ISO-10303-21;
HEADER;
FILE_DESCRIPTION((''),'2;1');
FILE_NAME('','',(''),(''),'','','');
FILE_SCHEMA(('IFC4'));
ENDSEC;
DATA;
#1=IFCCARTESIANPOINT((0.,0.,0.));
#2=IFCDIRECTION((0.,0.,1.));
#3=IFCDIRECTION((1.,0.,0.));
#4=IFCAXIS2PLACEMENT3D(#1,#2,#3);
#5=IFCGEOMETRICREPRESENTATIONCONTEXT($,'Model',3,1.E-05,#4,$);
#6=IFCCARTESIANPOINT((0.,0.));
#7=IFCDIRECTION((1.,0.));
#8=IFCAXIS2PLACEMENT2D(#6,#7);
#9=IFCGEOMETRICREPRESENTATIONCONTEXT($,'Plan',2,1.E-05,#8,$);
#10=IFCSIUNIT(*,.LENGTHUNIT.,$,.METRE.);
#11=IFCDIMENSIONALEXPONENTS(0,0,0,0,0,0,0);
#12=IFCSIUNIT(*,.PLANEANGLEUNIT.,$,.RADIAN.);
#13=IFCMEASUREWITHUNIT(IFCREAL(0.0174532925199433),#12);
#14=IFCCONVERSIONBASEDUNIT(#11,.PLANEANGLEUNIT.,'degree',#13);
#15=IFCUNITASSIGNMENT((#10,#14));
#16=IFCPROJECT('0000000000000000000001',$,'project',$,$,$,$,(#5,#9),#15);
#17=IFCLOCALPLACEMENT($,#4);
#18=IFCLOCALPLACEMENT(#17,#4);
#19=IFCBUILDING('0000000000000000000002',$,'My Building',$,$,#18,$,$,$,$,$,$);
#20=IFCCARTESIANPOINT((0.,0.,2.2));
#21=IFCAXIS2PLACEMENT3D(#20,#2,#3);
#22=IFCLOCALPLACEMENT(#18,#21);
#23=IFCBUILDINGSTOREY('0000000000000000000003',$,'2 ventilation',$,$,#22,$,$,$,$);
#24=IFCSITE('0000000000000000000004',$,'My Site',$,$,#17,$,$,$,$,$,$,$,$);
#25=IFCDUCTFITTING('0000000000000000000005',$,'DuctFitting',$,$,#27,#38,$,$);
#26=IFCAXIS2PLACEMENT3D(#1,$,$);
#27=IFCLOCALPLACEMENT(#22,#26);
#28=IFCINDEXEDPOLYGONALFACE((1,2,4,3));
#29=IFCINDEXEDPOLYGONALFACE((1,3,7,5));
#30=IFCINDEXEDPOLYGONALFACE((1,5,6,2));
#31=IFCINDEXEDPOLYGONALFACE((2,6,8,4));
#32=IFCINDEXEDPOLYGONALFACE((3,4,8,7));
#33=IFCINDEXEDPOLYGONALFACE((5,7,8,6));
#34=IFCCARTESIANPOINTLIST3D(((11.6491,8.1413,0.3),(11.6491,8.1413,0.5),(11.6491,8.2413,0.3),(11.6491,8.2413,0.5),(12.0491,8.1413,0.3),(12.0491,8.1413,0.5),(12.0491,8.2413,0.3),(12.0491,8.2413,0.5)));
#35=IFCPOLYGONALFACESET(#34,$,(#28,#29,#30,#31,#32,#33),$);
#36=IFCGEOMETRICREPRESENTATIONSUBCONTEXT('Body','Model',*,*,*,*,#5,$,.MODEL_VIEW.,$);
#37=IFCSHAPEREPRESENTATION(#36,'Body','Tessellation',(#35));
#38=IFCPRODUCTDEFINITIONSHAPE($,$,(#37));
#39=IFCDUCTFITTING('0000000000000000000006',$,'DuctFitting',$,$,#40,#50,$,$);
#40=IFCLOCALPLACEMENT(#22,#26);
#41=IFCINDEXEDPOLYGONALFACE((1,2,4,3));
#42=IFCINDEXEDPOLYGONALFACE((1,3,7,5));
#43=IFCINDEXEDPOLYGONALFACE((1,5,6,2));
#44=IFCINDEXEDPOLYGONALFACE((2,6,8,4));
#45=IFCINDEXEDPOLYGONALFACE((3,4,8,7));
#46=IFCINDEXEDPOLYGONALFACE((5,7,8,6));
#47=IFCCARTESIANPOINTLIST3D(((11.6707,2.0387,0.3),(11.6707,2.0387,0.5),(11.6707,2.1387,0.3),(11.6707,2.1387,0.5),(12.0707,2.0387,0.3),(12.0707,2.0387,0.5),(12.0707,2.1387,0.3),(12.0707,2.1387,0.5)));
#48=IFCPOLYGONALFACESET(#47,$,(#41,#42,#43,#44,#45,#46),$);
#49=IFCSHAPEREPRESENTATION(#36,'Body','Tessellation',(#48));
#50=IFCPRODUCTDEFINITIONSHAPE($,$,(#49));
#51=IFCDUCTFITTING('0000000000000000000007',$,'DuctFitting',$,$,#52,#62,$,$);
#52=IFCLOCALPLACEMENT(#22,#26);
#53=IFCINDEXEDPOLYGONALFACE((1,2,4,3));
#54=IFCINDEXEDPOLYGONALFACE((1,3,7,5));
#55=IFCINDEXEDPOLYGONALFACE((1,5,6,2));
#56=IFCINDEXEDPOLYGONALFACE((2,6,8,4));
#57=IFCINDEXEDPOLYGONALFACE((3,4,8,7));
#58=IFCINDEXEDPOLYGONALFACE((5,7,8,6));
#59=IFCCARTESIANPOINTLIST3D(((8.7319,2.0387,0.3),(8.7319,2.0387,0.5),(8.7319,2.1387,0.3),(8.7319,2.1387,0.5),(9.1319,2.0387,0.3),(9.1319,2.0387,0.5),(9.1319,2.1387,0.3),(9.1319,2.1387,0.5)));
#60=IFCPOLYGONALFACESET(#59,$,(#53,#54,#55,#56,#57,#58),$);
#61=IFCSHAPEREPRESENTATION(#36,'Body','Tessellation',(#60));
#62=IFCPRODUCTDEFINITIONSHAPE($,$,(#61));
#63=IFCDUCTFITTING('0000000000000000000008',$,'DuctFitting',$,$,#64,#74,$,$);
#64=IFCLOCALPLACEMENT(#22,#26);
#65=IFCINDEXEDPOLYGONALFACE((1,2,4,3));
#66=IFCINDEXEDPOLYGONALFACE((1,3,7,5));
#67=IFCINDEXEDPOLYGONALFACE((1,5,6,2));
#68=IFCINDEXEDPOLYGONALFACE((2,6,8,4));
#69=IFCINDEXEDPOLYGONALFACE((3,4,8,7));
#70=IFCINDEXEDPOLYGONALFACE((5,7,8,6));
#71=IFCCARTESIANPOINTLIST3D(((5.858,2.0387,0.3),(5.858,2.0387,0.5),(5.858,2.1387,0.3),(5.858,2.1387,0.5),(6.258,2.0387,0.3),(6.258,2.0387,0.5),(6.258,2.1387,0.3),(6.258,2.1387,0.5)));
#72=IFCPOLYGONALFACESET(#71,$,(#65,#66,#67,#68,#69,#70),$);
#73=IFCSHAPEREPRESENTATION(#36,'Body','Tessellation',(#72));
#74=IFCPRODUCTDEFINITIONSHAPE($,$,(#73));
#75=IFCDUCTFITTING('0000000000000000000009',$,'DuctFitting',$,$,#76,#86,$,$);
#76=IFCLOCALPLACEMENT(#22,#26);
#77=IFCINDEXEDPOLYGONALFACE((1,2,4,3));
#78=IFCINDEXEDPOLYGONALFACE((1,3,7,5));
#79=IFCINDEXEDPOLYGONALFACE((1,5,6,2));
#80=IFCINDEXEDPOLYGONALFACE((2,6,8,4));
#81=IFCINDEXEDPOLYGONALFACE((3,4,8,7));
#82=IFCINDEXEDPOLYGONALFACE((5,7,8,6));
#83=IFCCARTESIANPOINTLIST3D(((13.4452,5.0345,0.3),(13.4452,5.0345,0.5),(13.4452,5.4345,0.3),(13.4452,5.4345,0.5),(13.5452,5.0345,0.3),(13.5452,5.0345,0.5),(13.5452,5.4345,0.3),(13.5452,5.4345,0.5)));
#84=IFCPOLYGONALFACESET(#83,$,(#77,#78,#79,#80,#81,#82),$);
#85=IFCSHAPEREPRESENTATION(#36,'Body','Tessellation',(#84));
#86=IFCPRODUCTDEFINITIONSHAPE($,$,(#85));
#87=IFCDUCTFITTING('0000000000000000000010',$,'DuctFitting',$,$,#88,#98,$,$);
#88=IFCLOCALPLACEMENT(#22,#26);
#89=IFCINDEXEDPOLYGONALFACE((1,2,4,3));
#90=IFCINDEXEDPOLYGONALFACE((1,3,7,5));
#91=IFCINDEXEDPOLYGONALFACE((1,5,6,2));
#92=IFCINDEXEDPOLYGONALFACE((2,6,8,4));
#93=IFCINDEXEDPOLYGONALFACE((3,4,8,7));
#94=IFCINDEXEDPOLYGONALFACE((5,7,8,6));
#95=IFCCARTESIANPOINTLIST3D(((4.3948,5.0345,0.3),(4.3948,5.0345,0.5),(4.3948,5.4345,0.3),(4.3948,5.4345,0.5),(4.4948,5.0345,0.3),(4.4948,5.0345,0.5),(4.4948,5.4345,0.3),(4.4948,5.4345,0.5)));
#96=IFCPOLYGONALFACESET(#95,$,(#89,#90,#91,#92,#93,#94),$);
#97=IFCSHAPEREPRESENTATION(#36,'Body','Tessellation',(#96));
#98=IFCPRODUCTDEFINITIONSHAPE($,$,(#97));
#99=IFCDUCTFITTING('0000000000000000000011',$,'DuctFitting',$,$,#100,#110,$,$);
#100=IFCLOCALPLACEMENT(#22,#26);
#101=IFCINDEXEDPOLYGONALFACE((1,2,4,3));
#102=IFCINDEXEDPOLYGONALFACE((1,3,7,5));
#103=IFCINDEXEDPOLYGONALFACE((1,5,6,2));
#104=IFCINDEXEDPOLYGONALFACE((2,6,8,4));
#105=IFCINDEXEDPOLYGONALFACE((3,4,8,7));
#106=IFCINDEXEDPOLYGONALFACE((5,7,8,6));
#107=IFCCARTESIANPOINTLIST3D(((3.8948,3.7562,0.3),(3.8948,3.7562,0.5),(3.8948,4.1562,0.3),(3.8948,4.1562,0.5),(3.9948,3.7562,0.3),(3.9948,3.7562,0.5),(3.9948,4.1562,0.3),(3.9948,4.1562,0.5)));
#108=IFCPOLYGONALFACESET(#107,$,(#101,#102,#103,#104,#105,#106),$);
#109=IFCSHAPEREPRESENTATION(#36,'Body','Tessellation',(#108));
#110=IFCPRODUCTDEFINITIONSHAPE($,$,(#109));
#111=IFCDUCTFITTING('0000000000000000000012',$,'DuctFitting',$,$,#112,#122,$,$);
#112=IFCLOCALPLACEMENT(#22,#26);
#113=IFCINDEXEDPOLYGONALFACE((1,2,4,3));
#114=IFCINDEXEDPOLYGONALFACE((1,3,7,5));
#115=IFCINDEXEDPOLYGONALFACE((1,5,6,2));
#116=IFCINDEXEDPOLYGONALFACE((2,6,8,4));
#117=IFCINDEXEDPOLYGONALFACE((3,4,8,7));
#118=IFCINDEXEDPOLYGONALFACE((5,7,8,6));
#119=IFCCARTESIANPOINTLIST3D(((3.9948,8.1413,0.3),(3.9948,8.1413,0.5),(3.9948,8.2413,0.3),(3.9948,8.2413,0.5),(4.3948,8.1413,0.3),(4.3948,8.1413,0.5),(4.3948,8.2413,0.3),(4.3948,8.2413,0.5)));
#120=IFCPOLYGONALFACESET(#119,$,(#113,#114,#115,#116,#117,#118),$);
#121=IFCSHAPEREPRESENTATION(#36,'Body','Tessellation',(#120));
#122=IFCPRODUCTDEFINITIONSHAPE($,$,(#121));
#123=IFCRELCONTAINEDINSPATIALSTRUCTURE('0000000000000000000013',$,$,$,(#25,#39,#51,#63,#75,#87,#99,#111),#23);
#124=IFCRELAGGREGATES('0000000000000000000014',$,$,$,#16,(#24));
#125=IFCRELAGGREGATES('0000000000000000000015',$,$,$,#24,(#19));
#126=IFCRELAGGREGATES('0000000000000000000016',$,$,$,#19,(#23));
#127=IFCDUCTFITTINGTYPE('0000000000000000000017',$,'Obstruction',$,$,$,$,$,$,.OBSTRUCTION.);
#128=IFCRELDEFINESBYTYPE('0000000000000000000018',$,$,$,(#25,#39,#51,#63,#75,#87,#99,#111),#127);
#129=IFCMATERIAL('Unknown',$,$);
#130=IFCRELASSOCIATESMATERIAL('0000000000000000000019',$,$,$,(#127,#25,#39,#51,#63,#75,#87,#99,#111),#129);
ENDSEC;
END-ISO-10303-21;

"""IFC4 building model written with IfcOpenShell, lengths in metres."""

from ifc_helpers import new_model, entity, si_unit, converted_unit, frame, origin_with_axes, origin_2d_with_axis, place, context, subcontext, project, spatial, indexed_curve, outline, extrude, material, material_profile, profile_set, profile_usage, type_object, element, save


model = new_model("IFC4")

# Units and contexts
model_context = context("Model", 3, precision=1e-05, world=origin_with_axes())
plan_context = context("Plan", 2, precision=1e-05, world=origin_2d_with_axis())
body_context = subcontext(model_context, "Body", "Model", "MODEL_VIEW")
ifc_project = project(units=[si_unit("LENGTHUNIT", "METRE"), converted_unit("PLANEANGLEUNIT", "degree", entity("IfcReal", 0.0174532925199433), si_unit("PLANEANGLEUNIT", "RADIAN"), dimensions=[0, 0, 0, 0, 0, 0, 0])], contexts=[model_context, plan_context])

# Site, building, storey
site_placement = place(None, origin_with_axes())
site = spatial("IfcSite", under=ifc_project, at=site_placement, Name="My Site")
building_placement = place(site_placement, origin_with_axes())
building = spatial("IfcBuilding", under=site, at=building_placement, Name="My Building")
storey_placement = place(building_placement, frame((0.0, 0.0, 2.2), z_axis=(0.0, 0.0, 1.0), x_axis=(1.0, 0.0, 0.0)))
storey = spatial("IfcBuildingStorey", under=building, at=storey_placement, Name="2 ventilation")

# Shared definitions
ifc_material = material(Name="Unknown")

# Duct fittings
ifc_material_profile_1 = material_profile(ifc_material, outline(indexed_curve([(-0.2, 0.1), (0.2, 0.1), (0.2, -0.1), (-0.2, -0.1), (-0.2, 0.1)])))
ifc_profile_set_1 = profile_set([ifc_material_profile_1])
duct_fitting_type_1 = type_object("IfcDuctFittingType", Name="Obstruction", PredefinedType="OBSTRUCTION", material=ifc_profile_set_1)
ifc_profile_usage_1 = profile_usage(ifc_profile_set_1, cardinal=2)
duct_fitting_1_placement = place(storey_placement, frame((11.8491, 8.1413, 0.3), z_axis=(0.0, 1.0, 0.000007), x_axis=(-1.0, 0.0, 0.0)))
element("IfcDuctFitting", 1, at=duct_fitting_1_placement, inside=storey, type_object=duct_fitting_type_1, material=ifc_profile_usage_1, Name="DuctFitting", context=body_context, shape_type="SweptSolid", body=[
    extrude(outline(indexed_curve([(-0.2, 0.1), (0.2, 0.1), (0.2, -0.1), (-0.2, -0.1), (-0.2, 0.1)])), frame((0.0, 0.1, 0.0), z_axis=(0.0, 0.0, 1.0), x_axis=(1.0, 0.0, 0.0)), (0.0, 0.0, 1.0), 0.1),
])
ifc_profile_usage_2 = profile_usage(ifc_profile_set_1, cardinal=2)
duct_fitting_2_placement = place(storey_placement, frame((11.8707, 2.1387, 0.3), z_axis=(0.0, -1.0, 0.000007), x_axis=(1.0, 0.0, 0.0)))
element("IfcDuctFitting", 2, at=duct_fitting_2_placement, inside=storey, type_object=duct_fitting_type_1, material=ifc_profile_usage_2, Name="DuctFitting", context=body_context, shape_type="SweptSolid", body=[
    extrude(outline(indexed_curve([(-0.2, 0.1), (0.2, 0.1), (0.2, -0.1), (-0.2, -0.1), (-0.2, 0.1)])), frame((0.0, 0.1, 0.0), z_axis=(0.0, 0.0, 1.0), x_axis=(1.0, 0.0, 0.0)), (0.0, 0.0, 1.0), 0.1),
])
ifc_profile_usage_3 = profile_usage(ifc_profile_set_1, cardinal=2)
duct_fitting_3_placement = place(storey_placement, frame((8.9319, 2.1387, 0.3), z_axis=(0.0, -1.0, 0.000007), x_axis=(1.0, 0.0, 0.0)))
element("IfcDuctFitting", 3, at=duct_fitting_3_placement, inside=storey, type_object=duct_fitting_type_1, material=ifc_profile_usage_3, Name="DuctFitting", context=body_context, shape_type="SweptSolid", body=[
    extrude(outline(indexed_curve([(-0.2, 0.1), (0.2, 0.1), (0.2, -0.1), (-0.2, -0.1), (-0.2, 0.1)])), frame((0.0, 0.1, 0.0), z_axis=(0.0, 0.0, 1.0), x_axis=(1.0, 0.0, 0.0)), (0.0, 0.0, 1.0), 0.1),
])
ifc_profile_usage_4 = profile_usage(ifc_profile_set_1, cardinal=2)
duct_fitting_4_placement = place(storey_placement, frame((6.058, 2.1387, 0.3), z_axis=(0.0, -1.0, 0.000007), x_axis=(1.0, 0.0, 0.0)))
element("IfcDuctFitting", 4, at=duct_fitting_4_placement, inside=storey, type_object=duct_fitting_type_1, material=ifc_profile_usage_4, Name="DuctFitting", context=body_context, shape_type="SweptSolid", body=[
    extrude(outline(indexed_curve([(-0.2, 0.1), (0.2, 0.1), (0.2, -0.1), (-0.2, -0.1), (-0.2, 0.1)])), frame((0.0, 0.1, 0.0), z_axis=(0.0, 0.0, 1.0), x_axis=(1.0, 0.0, 0.0)), (0.0, 0.0, 1.0), 0.1),
])
ifc_profile_usage_5 = profile_usage(ifc_profile_set_1, cardinal=2)
duct_fitting_5_placement = place(storey_placement, frame((13.4452, 5.2345, 0.3), z_axis=(1.0, 0.0, 0.000007), x_axis=(0.0, 1.0, 0.0)))
element("IfcDuctFitting", 5, at=duct_fitting_5_placement, inside=storey, type_object=duct_fitting_type_1, material=ifc_profile_usage_5, Name="DuctFitting", context=body_context, shape_type="SweptSolid", body=[
    extrude(outline(indexed_curve([(-0.2, 0.1), (0.2, 0.1), (0.2, -0.1), (-0.2, -0.1), (-0.2, 0.1)])), frame((0.0, 0.1, 0.0), z_axis=(0.0, 0.0, 1.0), x_axis=(1.0, 0.0, 0.0)), (0.0, 0.0, 1.0), 0.1),
])
ifc_profile_usage_6 = profile_usage(ifc_profile_set_1, cardinal=2)
duct_fitting_6_placement = place(storey_placement, frame((4.4948, 5.2345, 0.3), z_axis=(-1.0, 0.0, 0.000007), x_axis=(0.0, -1.0, 0.0)))
element("IfcDuctFitting", 6, at=duct_fitting_6_placement, inside=storey, type_object=duct_fitting_type_1, material=ifc_profile_usage_6, Name="DuctFitting", context=body_context, shape_type="SweptSolid", body=[
    extrude(outline(indexed_curve([(-0.2, 0.1), (0.2, 0.1), (0.2, -0.1), (-0.2, -0.1), (-0.2, 0.1)])), frame((0.0, 0.1, 0.0), z_axis=(0.0, 0.0, 1.0), x_axis=(1.0, 0.0, 0.0)), (0.0, 0.0, 1.0), 0.1),
])
ifc_profile_usage_7 = profile_usage(ifc_profile_set_1, cardinal=2)
duct_fitting_7_placement = place(storey_placement, frame((3.8948, 3.9562, 0.3), z_axis=(1.0, 0.0, 0.000007), x_axis=(0.0, 1.0, 0.0)))
element("IfcDuctFitting", 7, at=duct_fitting_7_placement, inside=storey, type_object=duct_fitting_type_1, material=ifc_profile_usage_7, Name="DuctFitting", context=body_context, shape_type="SweptSolid", body=[
    extrude(outline(indexed_curve([(-0.2, 0.1), (0.2, 0.1), (0.2, -0.1), (-0.2, -0.1), (-0.2, 0.1)])), frame((0.0, 0.1, 0.0), z_axis=(0.0, 0.0, 1.0), x_axis=(1.0, 0.0, 0.0)), (0.0, 0.0, 1.0), 0.1),
])
ifc_profile_usage_8 = profile_usage(ifc_profile_set_1, cardinal=2)
duct_fitting_8_placement = place(storey_placement, frame((4.1948, 8.2413, 0.3), z_axis=(0.0, -1.0, 0.000001), x_axis=(1.0, 0.0, 0.0)))
element("IfcDuctFitting", 8, at=duct_fitting_8_placement, inside=storey, type_object=duct_fitting_type_1, material=ifc_profile_usage_8, Name="DuctFitting", context=body_context, shape_type="SweptSolid", body=[
    extrude(outline(indexed_curve([(-0.2, 0.1), (0.2, 0.1), (0.2, -0.1), (-0.2, -0.1), (-0.2, 0.1)])), frame((0.0, 0.1, 0.0), z_axis=(0.0, 0.0, 1.0), x_axis=(1.0, 0.0, 0.0)), (0.0, 0.0, 1.0), 0.1),
])

save(model, "model.ifc")
